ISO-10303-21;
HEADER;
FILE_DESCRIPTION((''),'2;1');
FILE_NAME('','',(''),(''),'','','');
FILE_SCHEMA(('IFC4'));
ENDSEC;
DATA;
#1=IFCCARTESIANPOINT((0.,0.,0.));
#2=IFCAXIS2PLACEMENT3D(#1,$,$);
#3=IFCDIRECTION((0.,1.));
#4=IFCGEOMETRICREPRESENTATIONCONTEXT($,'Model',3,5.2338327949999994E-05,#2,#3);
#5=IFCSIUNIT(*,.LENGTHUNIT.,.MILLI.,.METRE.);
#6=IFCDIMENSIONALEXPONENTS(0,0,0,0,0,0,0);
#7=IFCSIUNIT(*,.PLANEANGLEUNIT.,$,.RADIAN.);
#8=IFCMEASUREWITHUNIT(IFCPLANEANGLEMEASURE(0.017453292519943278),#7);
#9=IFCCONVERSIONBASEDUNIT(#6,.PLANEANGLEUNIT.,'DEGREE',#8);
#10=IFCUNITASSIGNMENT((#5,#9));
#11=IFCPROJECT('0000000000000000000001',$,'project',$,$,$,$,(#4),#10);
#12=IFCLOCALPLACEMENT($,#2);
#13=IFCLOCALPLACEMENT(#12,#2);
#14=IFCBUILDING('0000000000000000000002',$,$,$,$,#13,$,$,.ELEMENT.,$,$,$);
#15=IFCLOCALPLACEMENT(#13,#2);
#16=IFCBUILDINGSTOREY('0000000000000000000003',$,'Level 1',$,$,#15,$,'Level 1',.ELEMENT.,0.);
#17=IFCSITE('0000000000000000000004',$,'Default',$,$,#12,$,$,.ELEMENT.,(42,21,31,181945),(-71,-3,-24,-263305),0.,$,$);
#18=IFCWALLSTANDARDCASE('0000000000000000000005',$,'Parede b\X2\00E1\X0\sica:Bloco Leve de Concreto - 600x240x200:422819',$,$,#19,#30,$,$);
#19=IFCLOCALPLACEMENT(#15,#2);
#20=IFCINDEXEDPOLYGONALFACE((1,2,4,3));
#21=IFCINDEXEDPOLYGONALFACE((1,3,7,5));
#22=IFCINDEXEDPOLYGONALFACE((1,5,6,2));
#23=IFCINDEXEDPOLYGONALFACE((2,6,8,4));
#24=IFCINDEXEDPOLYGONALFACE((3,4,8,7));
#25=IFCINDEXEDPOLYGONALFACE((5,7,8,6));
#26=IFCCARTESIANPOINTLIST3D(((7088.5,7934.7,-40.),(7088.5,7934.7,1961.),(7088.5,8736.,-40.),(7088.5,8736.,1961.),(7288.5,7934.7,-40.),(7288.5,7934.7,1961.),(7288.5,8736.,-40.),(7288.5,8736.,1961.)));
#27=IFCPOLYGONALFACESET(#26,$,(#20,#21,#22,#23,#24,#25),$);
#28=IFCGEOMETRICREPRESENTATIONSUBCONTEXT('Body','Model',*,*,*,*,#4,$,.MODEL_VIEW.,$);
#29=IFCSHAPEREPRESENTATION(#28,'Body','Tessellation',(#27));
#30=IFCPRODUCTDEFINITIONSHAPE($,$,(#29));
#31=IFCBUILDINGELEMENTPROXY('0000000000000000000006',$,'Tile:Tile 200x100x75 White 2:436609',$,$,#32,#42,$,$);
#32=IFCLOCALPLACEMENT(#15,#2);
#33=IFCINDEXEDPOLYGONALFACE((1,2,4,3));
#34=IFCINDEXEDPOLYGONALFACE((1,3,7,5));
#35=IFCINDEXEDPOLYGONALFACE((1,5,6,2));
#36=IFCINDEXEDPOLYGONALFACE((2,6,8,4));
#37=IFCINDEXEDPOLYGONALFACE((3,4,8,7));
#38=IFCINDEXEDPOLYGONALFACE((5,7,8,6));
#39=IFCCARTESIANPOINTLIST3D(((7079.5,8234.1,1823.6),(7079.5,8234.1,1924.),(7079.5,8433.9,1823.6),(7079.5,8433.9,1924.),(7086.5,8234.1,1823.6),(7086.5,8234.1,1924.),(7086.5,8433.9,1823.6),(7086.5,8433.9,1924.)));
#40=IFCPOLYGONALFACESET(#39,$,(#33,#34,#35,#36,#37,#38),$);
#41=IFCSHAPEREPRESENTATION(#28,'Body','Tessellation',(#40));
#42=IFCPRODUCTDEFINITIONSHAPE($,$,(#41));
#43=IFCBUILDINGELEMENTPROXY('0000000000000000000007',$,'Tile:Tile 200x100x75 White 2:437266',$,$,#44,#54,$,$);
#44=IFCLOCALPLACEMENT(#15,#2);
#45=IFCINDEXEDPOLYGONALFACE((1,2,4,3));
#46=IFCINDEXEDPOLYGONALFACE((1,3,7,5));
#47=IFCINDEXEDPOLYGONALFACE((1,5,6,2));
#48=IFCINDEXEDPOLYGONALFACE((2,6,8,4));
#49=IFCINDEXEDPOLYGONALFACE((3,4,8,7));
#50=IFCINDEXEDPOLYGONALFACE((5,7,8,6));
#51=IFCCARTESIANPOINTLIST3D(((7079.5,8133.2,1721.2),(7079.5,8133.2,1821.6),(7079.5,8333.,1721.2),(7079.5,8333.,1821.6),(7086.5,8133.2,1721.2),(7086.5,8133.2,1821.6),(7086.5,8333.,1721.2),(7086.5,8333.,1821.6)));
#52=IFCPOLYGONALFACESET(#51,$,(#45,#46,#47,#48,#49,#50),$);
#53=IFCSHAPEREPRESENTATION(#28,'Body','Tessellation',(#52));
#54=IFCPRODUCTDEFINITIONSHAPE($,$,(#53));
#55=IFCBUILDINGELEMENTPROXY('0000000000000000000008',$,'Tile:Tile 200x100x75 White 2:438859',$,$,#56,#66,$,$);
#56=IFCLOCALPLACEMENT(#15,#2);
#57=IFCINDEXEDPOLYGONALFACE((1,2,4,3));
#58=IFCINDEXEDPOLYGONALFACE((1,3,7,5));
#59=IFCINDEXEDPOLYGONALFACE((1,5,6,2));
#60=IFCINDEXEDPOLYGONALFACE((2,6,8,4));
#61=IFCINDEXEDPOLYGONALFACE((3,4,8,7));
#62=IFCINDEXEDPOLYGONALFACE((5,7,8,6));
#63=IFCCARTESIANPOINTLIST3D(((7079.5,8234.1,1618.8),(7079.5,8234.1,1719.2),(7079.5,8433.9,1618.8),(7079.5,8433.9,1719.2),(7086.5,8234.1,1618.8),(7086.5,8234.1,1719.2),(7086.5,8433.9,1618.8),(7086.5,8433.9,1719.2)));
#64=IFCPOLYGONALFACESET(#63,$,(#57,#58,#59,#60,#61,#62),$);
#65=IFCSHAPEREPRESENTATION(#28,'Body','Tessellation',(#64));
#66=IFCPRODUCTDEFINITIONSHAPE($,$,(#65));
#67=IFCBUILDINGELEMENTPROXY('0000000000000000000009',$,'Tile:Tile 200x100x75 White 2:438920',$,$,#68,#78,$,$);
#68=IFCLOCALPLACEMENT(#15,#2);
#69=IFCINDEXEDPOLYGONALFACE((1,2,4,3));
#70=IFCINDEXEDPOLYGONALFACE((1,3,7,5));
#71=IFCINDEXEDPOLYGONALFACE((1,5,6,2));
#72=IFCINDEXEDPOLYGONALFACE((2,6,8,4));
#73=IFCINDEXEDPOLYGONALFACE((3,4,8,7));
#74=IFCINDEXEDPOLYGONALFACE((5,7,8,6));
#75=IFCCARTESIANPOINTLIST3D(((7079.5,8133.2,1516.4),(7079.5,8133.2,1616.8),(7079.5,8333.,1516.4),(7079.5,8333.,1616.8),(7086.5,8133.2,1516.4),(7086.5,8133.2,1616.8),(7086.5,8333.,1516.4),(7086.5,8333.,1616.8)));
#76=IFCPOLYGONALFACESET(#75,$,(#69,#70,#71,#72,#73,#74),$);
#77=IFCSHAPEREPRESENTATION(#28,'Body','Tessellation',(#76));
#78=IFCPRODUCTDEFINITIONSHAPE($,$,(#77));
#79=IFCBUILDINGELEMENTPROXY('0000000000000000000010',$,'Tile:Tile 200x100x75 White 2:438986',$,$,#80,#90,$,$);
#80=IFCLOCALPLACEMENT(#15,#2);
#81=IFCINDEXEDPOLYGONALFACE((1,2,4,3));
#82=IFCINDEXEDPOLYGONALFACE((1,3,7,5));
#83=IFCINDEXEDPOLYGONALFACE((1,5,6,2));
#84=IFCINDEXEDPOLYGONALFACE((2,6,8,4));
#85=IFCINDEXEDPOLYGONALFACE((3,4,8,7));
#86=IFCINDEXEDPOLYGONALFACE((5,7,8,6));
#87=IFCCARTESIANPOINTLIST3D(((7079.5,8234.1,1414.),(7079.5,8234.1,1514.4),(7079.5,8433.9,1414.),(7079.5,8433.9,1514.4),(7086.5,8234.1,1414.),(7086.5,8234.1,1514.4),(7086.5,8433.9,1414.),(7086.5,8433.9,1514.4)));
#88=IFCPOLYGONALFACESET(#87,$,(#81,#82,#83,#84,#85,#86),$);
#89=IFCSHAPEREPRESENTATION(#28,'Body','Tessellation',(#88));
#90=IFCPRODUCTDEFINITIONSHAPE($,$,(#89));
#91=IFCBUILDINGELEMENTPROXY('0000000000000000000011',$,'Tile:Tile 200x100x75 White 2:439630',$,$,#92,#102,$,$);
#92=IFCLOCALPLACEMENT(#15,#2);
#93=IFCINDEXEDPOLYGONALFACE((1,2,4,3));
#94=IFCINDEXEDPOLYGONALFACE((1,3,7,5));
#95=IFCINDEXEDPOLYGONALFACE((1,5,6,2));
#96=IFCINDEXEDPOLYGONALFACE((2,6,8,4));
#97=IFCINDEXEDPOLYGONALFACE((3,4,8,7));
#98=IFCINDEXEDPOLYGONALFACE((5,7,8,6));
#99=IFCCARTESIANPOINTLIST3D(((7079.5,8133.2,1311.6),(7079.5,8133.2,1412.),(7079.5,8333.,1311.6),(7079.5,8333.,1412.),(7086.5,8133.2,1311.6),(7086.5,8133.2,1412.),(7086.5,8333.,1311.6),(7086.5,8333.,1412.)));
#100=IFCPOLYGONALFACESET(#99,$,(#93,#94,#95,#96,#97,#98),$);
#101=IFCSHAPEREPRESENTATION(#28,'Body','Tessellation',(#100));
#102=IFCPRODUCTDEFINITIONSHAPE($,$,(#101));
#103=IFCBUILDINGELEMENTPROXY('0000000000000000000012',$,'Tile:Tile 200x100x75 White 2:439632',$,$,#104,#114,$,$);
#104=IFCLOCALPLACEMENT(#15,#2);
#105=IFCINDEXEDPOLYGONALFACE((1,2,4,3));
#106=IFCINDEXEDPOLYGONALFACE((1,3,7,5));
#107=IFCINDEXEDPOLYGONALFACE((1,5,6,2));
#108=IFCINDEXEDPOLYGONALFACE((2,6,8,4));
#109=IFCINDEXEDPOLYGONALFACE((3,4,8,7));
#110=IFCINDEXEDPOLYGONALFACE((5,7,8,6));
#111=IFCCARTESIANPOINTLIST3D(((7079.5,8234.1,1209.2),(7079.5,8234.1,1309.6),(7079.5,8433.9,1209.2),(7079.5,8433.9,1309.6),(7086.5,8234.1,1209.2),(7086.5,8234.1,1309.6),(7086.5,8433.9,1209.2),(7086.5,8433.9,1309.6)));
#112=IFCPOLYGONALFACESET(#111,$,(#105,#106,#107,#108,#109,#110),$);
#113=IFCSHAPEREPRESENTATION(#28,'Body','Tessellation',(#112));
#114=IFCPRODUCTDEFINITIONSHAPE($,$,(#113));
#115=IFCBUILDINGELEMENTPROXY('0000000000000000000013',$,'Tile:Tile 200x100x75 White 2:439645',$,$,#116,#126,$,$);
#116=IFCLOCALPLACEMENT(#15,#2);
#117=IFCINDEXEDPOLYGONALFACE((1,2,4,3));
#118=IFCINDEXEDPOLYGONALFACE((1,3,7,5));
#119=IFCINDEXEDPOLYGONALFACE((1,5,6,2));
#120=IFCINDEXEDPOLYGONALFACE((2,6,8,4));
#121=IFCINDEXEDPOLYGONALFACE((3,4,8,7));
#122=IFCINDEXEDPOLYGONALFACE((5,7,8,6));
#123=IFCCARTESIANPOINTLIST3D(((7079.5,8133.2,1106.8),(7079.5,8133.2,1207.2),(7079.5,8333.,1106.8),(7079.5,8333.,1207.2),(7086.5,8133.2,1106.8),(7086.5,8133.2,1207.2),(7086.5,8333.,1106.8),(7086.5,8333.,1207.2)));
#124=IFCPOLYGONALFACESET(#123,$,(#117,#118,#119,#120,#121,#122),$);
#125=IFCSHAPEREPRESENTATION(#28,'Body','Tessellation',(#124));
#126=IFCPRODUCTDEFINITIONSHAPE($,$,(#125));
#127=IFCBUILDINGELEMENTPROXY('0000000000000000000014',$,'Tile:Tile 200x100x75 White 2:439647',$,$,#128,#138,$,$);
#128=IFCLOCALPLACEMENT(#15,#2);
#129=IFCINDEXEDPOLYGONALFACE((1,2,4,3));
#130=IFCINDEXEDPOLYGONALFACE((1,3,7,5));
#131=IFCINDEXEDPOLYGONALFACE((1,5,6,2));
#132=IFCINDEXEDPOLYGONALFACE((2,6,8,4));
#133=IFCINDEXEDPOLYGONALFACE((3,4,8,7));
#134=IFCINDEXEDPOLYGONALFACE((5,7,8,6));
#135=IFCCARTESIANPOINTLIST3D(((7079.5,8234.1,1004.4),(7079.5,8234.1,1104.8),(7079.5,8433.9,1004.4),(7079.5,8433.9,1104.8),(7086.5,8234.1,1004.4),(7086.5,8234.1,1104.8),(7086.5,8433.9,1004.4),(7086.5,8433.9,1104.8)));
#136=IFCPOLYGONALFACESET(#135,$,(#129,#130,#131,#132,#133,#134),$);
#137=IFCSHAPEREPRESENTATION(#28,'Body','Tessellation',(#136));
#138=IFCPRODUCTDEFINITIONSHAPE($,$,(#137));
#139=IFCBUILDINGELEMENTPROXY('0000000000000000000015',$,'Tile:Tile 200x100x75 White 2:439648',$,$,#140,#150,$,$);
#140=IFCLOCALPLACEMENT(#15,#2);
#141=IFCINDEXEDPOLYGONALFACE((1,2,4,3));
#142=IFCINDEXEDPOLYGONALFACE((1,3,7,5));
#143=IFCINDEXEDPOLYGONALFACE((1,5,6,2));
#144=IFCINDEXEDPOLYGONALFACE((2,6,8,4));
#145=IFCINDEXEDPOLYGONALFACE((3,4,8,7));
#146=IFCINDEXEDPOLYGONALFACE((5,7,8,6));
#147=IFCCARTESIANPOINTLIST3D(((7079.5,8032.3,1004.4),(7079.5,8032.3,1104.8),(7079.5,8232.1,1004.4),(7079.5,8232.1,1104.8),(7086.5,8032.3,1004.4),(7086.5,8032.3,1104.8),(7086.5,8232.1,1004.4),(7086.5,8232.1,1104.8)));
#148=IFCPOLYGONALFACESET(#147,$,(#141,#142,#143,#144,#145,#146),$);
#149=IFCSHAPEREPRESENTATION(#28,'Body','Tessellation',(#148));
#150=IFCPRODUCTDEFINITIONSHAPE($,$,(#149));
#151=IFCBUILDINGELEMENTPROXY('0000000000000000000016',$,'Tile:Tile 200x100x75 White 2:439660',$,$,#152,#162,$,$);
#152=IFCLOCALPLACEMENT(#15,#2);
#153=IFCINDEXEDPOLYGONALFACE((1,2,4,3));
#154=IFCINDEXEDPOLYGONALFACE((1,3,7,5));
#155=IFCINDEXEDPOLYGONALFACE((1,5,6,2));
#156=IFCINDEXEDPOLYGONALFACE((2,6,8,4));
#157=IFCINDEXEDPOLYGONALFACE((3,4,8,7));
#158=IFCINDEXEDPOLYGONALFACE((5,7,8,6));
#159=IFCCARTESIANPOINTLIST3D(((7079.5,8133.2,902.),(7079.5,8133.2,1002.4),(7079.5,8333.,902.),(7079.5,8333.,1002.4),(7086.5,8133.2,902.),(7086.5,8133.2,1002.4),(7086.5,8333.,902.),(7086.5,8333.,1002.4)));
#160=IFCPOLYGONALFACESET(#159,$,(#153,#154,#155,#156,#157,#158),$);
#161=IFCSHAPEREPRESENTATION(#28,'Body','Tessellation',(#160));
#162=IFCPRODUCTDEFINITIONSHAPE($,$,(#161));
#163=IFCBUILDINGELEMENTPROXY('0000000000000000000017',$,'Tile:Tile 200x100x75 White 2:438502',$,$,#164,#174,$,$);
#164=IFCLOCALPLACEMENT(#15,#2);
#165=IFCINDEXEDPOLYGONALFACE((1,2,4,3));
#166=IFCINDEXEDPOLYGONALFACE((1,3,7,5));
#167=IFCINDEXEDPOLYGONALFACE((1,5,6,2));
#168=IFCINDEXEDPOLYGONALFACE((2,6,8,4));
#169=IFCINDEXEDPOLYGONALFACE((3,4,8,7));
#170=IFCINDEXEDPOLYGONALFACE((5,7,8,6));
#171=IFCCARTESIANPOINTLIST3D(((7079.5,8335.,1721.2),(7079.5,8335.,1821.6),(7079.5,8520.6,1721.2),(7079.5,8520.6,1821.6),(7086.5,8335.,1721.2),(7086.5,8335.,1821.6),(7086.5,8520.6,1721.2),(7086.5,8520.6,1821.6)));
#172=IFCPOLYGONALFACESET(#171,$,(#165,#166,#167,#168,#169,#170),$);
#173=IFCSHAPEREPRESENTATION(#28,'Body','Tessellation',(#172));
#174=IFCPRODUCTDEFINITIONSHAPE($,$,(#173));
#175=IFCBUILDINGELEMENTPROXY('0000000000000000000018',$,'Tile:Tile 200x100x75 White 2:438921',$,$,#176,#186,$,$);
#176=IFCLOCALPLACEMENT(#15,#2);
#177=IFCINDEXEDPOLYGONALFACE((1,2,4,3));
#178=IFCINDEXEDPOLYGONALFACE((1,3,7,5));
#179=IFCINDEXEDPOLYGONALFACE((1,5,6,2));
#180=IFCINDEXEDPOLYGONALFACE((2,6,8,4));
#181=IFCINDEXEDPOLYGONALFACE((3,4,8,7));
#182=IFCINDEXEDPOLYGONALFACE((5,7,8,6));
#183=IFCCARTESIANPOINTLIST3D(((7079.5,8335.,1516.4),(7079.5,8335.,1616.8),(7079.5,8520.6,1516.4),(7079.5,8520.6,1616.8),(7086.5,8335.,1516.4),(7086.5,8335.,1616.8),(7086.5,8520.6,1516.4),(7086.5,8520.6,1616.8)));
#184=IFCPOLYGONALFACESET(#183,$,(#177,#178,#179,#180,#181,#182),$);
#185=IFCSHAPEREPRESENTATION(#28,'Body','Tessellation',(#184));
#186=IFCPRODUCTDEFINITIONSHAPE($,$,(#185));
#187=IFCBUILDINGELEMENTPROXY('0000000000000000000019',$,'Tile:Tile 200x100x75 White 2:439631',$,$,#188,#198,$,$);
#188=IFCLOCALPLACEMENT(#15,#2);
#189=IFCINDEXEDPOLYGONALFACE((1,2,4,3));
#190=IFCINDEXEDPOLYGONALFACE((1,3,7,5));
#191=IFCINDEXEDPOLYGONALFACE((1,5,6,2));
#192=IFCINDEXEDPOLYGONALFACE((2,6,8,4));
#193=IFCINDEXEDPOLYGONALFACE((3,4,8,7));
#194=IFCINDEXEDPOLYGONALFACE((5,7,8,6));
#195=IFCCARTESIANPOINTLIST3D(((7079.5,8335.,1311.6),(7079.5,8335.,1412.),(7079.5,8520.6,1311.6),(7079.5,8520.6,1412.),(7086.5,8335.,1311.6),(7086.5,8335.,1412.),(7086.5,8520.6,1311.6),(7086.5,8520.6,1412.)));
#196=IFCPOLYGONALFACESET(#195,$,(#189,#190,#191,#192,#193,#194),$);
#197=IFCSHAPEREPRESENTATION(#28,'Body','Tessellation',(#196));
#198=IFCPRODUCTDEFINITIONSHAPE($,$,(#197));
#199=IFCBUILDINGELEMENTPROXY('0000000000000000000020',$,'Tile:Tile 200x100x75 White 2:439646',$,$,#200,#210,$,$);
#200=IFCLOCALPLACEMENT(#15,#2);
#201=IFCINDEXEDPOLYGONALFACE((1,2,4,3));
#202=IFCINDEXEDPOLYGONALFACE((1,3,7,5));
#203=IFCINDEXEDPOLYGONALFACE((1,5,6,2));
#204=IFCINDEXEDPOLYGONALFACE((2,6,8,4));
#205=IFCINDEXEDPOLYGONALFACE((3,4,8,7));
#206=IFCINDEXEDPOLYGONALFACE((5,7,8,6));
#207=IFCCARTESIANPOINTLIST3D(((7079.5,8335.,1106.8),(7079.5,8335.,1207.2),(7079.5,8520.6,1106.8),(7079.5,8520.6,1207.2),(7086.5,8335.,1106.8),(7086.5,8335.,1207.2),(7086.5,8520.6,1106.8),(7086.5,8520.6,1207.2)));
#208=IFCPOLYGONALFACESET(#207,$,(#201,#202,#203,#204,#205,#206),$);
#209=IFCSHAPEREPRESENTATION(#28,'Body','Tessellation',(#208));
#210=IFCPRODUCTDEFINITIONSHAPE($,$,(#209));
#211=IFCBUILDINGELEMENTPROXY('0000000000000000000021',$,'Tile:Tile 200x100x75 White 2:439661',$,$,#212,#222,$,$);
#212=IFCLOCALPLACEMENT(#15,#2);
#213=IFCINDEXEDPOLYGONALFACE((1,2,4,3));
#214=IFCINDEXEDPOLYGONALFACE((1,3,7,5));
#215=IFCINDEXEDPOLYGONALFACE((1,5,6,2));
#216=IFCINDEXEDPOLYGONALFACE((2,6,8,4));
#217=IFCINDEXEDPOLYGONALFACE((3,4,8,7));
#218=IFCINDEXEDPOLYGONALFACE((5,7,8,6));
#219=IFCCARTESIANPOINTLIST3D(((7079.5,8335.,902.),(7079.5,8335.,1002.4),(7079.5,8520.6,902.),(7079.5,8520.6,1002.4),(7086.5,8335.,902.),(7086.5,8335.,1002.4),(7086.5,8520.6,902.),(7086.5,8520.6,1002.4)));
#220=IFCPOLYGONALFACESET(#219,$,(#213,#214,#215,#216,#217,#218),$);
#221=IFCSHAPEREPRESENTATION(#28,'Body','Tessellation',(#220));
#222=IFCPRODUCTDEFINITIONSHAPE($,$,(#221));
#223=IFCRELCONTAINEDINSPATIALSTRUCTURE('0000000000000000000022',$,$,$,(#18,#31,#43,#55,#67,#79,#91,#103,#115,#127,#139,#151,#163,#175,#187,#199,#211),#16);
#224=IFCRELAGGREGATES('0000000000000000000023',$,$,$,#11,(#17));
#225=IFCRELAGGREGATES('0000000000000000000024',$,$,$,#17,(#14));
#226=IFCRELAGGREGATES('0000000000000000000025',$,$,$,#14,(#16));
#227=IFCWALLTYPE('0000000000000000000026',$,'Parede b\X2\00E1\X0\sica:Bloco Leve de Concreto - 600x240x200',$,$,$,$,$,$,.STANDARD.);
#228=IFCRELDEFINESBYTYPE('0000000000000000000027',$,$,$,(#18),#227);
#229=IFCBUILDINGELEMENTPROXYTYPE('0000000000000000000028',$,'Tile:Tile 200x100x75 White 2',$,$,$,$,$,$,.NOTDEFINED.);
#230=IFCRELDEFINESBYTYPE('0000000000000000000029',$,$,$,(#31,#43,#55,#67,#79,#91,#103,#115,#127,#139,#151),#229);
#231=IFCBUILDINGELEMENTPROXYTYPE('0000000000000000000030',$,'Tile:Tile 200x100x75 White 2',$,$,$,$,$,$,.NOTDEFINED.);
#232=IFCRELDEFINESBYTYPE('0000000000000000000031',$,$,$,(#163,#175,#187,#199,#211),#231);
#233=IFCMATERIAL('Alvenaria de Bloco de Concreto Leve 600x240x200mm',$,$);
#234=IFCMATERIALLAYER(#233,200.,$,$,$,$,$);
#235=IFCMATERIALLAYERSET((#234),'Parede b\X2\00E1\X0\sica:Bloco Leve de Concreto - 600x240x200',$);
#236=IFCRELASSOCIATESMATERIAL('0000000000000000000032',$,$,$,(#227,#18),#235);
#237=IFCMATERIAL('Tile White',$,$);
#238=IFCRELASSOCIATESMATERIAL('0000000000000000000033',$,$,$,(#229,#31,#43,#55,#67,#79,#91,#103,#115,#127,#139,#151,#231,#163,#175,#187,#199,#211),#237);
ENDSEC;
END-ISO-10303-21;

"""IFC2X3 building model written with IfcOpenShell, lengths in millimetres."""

from ifc_helpers import new_model, entity, si_unit, converted_unit, direction, frame, frame_2d, origin, place, context, subcontext, project, spatial, rectangle, extrude, source, transform, mapped, material, layer, layer_set, layer_usage, type_object, type_shapes, element, save


model = new_model("IFC2X3")

# Units and contexts
model_context = context("Model", 3, precision=5.2338327949999994e-05, world=origin(), true_north=direction((0.0, 1.0)))
body_context = subcontext(model_context, "Body", "Model", "MODEL_VIEW")
ifc_project = project(units=[si_unit("LENGTHUNIT", "METRE", prefix="MILLI"), converted_unit("PLANEANGLEUNIT", "DEGREE", entity("IfcPlaneAngleMeasure", 0.017453292519943278), si_unit("PLANEANGLEUNIT", "RADIAN"), dimensions=[0, 0, 0, 0, 0, 0, 0])], contexts=[model_context])

# Site, building, storey
site_placement = place(None, origin())
site = spatial("IfcSite", under=ifc_project, at=site_placement, Name="Default", CompositionType="ELEMENT", RefLatitude=(42, 21, 31, 181945), RefLongitude=(-71, -3, -24, -263305), RefElevation=0.0)
building_placement = place(site_placement, origin())
building = spatial("IfcBuilding", under=site, at=building_placement, CompositionType="ELEMENT")
storey_placement = place(building_placement, origin())
storey = spatial("IfcBuildingStorey", under=building, at=storey_placement, Name="Level 1", LongName="Level 1", CompositionType="ELEMENT", Elevation=0.0)

# Wall
ifc_material_1 = material(Name="Alvenaria de Bloco de Concreto Leve 600x240x200mm")
ifc_layer = layer(ifc_material_1, 200.0)
ifc_layer_set = layer_set([ifc_layer], Name="Parede básica:Bloco Leve de Concreto - 600x240x200")
ifc_layer_usage = layer_usage(ifc_layer_set, "AXIS2", "NEGATIVE", 100.0)
wall_type = type_object("IfcWallType", Name="Parede básica:Bloco Leve de Concreto - 600x240x200", PredefinedType="STANDARD", material=ifc_layer_set)
wall_placement = place(storey_placement, frame((7188.5, 8736.0, -40.0), z_axis=(0.0, 0.0, 1.0), x_axis=(0.0, -1.0, 0.0)))
element("IfcWallStandardCase", 1, at=wall_placement, inside=storey, type_object=wall_type, material=ifc_layer_usage, Name="Parede básica:Bloco Leve de Concreto - 600x240x200:422819", context=body_context, shape_type="SweptSolid", body=[
    extrude(rectangle(XDim=801.4, YDim=200.0, at=frame_2d((400.7, 0.0), x_axis=(-1.0, 0.0))), origin(), (0.0, 0.0, 1.0), 2001.0),
])

# Building element proxies
ifc_material_2 = material(Name="Tile White")
building_element_proxy_type_1 = type_object("IfcBuildingElementProxyType", Name="Tile:Tile 200x100x75 White 2", PredefinedType="NOTDEFINED", material=ifc_material_2)
shared_shape_1 = source(origin(), body_context, "Body", "SweptSolid", [
    extrude(rectangle(XDim=199.8, YDim=100.4, at=frame_2d((0.0, 0.0), x_axis=(1.0, 0.0))), frame((-50.2, -99.9, 0.0), z_axis=(0.0, 0.0, 1.0), x_axis=(0.0, -1.0, 0.0)), (0.0, 0.0, 1.0), 7.0),
])
type_shapes(building_element_proxy_type_1, [shared_shape_1])
for number, where, z_axis, x_axis, name in (
    (2, (7086.5, 8433.9, 1924.0), (-1.0, 0.0, 0.0), (0.0, 0.0, 1.0), "Tile:Tile 200x100x75 White 2:436609"),
    (3, (7086.5, 8333.0, 1821.6), (-1.0, 0.0, 0.0), (0.0, 0.0, 1.0), "Tile:Tile 200x100x75 White 2:437266"),
    (4, (7086.5, 8433.9, 1719.2), (-1.0, 0.0, 0.0), (0.0, 0.0, 1.0), "Tile:Tile 200x100x75 White 2:438859"),
    (5, (7086.5, 8333.0, 1616.8), (-1.0, 0.0, 0.0), (0.0, 0.0, 1.0), "Tile:Tile 200x100x75 White 2:438920"),
    (6, (7086.5, 8433.9, 1514.4), (-1.0, 0.0, 0.0), (0.0, 0.0, 1.0), "Tile:Tile 200x100x75 White 2:438986"),
    (7, (7086.5, 8333.0, 1412.0), (-1.0, 0.0, 0.0), (0.0, 0.0, 1.0), "Tile:Tile 200x100x75 White 2:439630"),
    (8, (7086.5, 8433.9, 1309.6), (-1.0, 0.0, 0.0), (0.0, 0.0, 1.0), "Tile:Tile 200x100x75 White 2:439632"),
    (9, (7086.5, 8333.0, 1207.2), (-1.0, 0.0, 0.0), (0.0, 0.0, 1.0), "Tile:Tile 200x100x75 White 2:439645"),
    (10, (7086.5, 8433.9, 1104.8), (-1.0, 0.0, 0.0), (0.0, 0.0, 1.0), "Tile:Tile 200x100x75 White 2:439647"),
    (11, (7086.5, 8232.1, 1104.8), (-1.0, 0.0, 0.0), (0.0, 0.0, 1.0), "Tile:Tile 200x100x75 White 2:439648"),
    (12, (7086.5, 8333.0, 1002.4), (-1.0, 0.0, 0.0), (0.0, 0.0, 1.0), "Tile:Tile 200x100x75 White 2:439660"),
):
    element("IfcBuildingElementProxy", number, at=place(storey_placement, frame(where, z_axis=z_axis, x_axis=x_axis)), inside=storey, type_object=building_element_proxy_type_1, material=ifc_material_2, Name=name, context=body_context, shape_type="MappedRepresentation", body=[
        mapped(shared_shape_1, transform((0.0, 0.0, 0.0), scale=1.0)),
    ])
building_element_proxy_type_2 = type_object("IfcBuildingElementProxyType", Name="Tile:Tile 200x100x75 White 2", PredefinedType="NOTDEFINED", material=ifc_material_2)
shared_shape_2 = source(origin(), body_context, "Body", "SweptSolid", [
    extrude(rectangle(XDim=185.6, YDim=100.4, at=frame_2d((0.0, 0.0), x_axis=(1.0, 0.0))), frame((-50.2, -92.8, 0.0), z_axis=(0.0, 0.0, 1.0), x_axis=(0.0, -1.0, 0.0)), (0.0, 0.0, 1.0), 7.0),
])
type_shapes(building_element_proxy_type_2, [shared_shape_2])
for number, where, z_axis, x_axis, name in (
    (13, (7086.5, 8520.6, 1821.6), (-1.0, 0.0, 0.0), (0.0, 0.0, 1.0), "Tile:Tile 200x100x75 White 2:438502"),
    (14, (7086.5, 8520.6, 1616.8), (-1.0, 0.0, 0.0), (0.0, 0.0, 1.0), "Tile:Tile 200x100x75 White 2:438921"),
    (15, (7086.5, 8520.6, 1412.0), (-1.0, 0.0, 0.0), (0.0, 0.0, 1.0), "Tile:Tile 200x100x75 White 2:439631"),
    (16, (7086.5, 8520.6, 1207.2), (-1.0, 0.0, 0.0), (0.0, 0.0, 1.0), "Tile:Tile 200x100x75 White 2:439646"),
    (17, (7086.5, 8520.6, 1002.4), (-1.0, 0.0, 0.0), (0.0, 0.0, 1.0), "Tile:Tile 200x100x75 White 2:439661"),
):
    element("IfcBuildingElementProxy", number, at=place(storey_placement, frame(where, z_axis=z_axis, x_axis=x_axis)), inside=storey, type_object=building_element_proxy_type_2, material=ifc_material_2, Name=name, context=body_context, shape_type="MappedRepresentation", body=[
        mapped(shared_shape_2, transform((0.0, 0.0, 0.0), scale=1.0)),
    ])

save(model, "model.ifc")
